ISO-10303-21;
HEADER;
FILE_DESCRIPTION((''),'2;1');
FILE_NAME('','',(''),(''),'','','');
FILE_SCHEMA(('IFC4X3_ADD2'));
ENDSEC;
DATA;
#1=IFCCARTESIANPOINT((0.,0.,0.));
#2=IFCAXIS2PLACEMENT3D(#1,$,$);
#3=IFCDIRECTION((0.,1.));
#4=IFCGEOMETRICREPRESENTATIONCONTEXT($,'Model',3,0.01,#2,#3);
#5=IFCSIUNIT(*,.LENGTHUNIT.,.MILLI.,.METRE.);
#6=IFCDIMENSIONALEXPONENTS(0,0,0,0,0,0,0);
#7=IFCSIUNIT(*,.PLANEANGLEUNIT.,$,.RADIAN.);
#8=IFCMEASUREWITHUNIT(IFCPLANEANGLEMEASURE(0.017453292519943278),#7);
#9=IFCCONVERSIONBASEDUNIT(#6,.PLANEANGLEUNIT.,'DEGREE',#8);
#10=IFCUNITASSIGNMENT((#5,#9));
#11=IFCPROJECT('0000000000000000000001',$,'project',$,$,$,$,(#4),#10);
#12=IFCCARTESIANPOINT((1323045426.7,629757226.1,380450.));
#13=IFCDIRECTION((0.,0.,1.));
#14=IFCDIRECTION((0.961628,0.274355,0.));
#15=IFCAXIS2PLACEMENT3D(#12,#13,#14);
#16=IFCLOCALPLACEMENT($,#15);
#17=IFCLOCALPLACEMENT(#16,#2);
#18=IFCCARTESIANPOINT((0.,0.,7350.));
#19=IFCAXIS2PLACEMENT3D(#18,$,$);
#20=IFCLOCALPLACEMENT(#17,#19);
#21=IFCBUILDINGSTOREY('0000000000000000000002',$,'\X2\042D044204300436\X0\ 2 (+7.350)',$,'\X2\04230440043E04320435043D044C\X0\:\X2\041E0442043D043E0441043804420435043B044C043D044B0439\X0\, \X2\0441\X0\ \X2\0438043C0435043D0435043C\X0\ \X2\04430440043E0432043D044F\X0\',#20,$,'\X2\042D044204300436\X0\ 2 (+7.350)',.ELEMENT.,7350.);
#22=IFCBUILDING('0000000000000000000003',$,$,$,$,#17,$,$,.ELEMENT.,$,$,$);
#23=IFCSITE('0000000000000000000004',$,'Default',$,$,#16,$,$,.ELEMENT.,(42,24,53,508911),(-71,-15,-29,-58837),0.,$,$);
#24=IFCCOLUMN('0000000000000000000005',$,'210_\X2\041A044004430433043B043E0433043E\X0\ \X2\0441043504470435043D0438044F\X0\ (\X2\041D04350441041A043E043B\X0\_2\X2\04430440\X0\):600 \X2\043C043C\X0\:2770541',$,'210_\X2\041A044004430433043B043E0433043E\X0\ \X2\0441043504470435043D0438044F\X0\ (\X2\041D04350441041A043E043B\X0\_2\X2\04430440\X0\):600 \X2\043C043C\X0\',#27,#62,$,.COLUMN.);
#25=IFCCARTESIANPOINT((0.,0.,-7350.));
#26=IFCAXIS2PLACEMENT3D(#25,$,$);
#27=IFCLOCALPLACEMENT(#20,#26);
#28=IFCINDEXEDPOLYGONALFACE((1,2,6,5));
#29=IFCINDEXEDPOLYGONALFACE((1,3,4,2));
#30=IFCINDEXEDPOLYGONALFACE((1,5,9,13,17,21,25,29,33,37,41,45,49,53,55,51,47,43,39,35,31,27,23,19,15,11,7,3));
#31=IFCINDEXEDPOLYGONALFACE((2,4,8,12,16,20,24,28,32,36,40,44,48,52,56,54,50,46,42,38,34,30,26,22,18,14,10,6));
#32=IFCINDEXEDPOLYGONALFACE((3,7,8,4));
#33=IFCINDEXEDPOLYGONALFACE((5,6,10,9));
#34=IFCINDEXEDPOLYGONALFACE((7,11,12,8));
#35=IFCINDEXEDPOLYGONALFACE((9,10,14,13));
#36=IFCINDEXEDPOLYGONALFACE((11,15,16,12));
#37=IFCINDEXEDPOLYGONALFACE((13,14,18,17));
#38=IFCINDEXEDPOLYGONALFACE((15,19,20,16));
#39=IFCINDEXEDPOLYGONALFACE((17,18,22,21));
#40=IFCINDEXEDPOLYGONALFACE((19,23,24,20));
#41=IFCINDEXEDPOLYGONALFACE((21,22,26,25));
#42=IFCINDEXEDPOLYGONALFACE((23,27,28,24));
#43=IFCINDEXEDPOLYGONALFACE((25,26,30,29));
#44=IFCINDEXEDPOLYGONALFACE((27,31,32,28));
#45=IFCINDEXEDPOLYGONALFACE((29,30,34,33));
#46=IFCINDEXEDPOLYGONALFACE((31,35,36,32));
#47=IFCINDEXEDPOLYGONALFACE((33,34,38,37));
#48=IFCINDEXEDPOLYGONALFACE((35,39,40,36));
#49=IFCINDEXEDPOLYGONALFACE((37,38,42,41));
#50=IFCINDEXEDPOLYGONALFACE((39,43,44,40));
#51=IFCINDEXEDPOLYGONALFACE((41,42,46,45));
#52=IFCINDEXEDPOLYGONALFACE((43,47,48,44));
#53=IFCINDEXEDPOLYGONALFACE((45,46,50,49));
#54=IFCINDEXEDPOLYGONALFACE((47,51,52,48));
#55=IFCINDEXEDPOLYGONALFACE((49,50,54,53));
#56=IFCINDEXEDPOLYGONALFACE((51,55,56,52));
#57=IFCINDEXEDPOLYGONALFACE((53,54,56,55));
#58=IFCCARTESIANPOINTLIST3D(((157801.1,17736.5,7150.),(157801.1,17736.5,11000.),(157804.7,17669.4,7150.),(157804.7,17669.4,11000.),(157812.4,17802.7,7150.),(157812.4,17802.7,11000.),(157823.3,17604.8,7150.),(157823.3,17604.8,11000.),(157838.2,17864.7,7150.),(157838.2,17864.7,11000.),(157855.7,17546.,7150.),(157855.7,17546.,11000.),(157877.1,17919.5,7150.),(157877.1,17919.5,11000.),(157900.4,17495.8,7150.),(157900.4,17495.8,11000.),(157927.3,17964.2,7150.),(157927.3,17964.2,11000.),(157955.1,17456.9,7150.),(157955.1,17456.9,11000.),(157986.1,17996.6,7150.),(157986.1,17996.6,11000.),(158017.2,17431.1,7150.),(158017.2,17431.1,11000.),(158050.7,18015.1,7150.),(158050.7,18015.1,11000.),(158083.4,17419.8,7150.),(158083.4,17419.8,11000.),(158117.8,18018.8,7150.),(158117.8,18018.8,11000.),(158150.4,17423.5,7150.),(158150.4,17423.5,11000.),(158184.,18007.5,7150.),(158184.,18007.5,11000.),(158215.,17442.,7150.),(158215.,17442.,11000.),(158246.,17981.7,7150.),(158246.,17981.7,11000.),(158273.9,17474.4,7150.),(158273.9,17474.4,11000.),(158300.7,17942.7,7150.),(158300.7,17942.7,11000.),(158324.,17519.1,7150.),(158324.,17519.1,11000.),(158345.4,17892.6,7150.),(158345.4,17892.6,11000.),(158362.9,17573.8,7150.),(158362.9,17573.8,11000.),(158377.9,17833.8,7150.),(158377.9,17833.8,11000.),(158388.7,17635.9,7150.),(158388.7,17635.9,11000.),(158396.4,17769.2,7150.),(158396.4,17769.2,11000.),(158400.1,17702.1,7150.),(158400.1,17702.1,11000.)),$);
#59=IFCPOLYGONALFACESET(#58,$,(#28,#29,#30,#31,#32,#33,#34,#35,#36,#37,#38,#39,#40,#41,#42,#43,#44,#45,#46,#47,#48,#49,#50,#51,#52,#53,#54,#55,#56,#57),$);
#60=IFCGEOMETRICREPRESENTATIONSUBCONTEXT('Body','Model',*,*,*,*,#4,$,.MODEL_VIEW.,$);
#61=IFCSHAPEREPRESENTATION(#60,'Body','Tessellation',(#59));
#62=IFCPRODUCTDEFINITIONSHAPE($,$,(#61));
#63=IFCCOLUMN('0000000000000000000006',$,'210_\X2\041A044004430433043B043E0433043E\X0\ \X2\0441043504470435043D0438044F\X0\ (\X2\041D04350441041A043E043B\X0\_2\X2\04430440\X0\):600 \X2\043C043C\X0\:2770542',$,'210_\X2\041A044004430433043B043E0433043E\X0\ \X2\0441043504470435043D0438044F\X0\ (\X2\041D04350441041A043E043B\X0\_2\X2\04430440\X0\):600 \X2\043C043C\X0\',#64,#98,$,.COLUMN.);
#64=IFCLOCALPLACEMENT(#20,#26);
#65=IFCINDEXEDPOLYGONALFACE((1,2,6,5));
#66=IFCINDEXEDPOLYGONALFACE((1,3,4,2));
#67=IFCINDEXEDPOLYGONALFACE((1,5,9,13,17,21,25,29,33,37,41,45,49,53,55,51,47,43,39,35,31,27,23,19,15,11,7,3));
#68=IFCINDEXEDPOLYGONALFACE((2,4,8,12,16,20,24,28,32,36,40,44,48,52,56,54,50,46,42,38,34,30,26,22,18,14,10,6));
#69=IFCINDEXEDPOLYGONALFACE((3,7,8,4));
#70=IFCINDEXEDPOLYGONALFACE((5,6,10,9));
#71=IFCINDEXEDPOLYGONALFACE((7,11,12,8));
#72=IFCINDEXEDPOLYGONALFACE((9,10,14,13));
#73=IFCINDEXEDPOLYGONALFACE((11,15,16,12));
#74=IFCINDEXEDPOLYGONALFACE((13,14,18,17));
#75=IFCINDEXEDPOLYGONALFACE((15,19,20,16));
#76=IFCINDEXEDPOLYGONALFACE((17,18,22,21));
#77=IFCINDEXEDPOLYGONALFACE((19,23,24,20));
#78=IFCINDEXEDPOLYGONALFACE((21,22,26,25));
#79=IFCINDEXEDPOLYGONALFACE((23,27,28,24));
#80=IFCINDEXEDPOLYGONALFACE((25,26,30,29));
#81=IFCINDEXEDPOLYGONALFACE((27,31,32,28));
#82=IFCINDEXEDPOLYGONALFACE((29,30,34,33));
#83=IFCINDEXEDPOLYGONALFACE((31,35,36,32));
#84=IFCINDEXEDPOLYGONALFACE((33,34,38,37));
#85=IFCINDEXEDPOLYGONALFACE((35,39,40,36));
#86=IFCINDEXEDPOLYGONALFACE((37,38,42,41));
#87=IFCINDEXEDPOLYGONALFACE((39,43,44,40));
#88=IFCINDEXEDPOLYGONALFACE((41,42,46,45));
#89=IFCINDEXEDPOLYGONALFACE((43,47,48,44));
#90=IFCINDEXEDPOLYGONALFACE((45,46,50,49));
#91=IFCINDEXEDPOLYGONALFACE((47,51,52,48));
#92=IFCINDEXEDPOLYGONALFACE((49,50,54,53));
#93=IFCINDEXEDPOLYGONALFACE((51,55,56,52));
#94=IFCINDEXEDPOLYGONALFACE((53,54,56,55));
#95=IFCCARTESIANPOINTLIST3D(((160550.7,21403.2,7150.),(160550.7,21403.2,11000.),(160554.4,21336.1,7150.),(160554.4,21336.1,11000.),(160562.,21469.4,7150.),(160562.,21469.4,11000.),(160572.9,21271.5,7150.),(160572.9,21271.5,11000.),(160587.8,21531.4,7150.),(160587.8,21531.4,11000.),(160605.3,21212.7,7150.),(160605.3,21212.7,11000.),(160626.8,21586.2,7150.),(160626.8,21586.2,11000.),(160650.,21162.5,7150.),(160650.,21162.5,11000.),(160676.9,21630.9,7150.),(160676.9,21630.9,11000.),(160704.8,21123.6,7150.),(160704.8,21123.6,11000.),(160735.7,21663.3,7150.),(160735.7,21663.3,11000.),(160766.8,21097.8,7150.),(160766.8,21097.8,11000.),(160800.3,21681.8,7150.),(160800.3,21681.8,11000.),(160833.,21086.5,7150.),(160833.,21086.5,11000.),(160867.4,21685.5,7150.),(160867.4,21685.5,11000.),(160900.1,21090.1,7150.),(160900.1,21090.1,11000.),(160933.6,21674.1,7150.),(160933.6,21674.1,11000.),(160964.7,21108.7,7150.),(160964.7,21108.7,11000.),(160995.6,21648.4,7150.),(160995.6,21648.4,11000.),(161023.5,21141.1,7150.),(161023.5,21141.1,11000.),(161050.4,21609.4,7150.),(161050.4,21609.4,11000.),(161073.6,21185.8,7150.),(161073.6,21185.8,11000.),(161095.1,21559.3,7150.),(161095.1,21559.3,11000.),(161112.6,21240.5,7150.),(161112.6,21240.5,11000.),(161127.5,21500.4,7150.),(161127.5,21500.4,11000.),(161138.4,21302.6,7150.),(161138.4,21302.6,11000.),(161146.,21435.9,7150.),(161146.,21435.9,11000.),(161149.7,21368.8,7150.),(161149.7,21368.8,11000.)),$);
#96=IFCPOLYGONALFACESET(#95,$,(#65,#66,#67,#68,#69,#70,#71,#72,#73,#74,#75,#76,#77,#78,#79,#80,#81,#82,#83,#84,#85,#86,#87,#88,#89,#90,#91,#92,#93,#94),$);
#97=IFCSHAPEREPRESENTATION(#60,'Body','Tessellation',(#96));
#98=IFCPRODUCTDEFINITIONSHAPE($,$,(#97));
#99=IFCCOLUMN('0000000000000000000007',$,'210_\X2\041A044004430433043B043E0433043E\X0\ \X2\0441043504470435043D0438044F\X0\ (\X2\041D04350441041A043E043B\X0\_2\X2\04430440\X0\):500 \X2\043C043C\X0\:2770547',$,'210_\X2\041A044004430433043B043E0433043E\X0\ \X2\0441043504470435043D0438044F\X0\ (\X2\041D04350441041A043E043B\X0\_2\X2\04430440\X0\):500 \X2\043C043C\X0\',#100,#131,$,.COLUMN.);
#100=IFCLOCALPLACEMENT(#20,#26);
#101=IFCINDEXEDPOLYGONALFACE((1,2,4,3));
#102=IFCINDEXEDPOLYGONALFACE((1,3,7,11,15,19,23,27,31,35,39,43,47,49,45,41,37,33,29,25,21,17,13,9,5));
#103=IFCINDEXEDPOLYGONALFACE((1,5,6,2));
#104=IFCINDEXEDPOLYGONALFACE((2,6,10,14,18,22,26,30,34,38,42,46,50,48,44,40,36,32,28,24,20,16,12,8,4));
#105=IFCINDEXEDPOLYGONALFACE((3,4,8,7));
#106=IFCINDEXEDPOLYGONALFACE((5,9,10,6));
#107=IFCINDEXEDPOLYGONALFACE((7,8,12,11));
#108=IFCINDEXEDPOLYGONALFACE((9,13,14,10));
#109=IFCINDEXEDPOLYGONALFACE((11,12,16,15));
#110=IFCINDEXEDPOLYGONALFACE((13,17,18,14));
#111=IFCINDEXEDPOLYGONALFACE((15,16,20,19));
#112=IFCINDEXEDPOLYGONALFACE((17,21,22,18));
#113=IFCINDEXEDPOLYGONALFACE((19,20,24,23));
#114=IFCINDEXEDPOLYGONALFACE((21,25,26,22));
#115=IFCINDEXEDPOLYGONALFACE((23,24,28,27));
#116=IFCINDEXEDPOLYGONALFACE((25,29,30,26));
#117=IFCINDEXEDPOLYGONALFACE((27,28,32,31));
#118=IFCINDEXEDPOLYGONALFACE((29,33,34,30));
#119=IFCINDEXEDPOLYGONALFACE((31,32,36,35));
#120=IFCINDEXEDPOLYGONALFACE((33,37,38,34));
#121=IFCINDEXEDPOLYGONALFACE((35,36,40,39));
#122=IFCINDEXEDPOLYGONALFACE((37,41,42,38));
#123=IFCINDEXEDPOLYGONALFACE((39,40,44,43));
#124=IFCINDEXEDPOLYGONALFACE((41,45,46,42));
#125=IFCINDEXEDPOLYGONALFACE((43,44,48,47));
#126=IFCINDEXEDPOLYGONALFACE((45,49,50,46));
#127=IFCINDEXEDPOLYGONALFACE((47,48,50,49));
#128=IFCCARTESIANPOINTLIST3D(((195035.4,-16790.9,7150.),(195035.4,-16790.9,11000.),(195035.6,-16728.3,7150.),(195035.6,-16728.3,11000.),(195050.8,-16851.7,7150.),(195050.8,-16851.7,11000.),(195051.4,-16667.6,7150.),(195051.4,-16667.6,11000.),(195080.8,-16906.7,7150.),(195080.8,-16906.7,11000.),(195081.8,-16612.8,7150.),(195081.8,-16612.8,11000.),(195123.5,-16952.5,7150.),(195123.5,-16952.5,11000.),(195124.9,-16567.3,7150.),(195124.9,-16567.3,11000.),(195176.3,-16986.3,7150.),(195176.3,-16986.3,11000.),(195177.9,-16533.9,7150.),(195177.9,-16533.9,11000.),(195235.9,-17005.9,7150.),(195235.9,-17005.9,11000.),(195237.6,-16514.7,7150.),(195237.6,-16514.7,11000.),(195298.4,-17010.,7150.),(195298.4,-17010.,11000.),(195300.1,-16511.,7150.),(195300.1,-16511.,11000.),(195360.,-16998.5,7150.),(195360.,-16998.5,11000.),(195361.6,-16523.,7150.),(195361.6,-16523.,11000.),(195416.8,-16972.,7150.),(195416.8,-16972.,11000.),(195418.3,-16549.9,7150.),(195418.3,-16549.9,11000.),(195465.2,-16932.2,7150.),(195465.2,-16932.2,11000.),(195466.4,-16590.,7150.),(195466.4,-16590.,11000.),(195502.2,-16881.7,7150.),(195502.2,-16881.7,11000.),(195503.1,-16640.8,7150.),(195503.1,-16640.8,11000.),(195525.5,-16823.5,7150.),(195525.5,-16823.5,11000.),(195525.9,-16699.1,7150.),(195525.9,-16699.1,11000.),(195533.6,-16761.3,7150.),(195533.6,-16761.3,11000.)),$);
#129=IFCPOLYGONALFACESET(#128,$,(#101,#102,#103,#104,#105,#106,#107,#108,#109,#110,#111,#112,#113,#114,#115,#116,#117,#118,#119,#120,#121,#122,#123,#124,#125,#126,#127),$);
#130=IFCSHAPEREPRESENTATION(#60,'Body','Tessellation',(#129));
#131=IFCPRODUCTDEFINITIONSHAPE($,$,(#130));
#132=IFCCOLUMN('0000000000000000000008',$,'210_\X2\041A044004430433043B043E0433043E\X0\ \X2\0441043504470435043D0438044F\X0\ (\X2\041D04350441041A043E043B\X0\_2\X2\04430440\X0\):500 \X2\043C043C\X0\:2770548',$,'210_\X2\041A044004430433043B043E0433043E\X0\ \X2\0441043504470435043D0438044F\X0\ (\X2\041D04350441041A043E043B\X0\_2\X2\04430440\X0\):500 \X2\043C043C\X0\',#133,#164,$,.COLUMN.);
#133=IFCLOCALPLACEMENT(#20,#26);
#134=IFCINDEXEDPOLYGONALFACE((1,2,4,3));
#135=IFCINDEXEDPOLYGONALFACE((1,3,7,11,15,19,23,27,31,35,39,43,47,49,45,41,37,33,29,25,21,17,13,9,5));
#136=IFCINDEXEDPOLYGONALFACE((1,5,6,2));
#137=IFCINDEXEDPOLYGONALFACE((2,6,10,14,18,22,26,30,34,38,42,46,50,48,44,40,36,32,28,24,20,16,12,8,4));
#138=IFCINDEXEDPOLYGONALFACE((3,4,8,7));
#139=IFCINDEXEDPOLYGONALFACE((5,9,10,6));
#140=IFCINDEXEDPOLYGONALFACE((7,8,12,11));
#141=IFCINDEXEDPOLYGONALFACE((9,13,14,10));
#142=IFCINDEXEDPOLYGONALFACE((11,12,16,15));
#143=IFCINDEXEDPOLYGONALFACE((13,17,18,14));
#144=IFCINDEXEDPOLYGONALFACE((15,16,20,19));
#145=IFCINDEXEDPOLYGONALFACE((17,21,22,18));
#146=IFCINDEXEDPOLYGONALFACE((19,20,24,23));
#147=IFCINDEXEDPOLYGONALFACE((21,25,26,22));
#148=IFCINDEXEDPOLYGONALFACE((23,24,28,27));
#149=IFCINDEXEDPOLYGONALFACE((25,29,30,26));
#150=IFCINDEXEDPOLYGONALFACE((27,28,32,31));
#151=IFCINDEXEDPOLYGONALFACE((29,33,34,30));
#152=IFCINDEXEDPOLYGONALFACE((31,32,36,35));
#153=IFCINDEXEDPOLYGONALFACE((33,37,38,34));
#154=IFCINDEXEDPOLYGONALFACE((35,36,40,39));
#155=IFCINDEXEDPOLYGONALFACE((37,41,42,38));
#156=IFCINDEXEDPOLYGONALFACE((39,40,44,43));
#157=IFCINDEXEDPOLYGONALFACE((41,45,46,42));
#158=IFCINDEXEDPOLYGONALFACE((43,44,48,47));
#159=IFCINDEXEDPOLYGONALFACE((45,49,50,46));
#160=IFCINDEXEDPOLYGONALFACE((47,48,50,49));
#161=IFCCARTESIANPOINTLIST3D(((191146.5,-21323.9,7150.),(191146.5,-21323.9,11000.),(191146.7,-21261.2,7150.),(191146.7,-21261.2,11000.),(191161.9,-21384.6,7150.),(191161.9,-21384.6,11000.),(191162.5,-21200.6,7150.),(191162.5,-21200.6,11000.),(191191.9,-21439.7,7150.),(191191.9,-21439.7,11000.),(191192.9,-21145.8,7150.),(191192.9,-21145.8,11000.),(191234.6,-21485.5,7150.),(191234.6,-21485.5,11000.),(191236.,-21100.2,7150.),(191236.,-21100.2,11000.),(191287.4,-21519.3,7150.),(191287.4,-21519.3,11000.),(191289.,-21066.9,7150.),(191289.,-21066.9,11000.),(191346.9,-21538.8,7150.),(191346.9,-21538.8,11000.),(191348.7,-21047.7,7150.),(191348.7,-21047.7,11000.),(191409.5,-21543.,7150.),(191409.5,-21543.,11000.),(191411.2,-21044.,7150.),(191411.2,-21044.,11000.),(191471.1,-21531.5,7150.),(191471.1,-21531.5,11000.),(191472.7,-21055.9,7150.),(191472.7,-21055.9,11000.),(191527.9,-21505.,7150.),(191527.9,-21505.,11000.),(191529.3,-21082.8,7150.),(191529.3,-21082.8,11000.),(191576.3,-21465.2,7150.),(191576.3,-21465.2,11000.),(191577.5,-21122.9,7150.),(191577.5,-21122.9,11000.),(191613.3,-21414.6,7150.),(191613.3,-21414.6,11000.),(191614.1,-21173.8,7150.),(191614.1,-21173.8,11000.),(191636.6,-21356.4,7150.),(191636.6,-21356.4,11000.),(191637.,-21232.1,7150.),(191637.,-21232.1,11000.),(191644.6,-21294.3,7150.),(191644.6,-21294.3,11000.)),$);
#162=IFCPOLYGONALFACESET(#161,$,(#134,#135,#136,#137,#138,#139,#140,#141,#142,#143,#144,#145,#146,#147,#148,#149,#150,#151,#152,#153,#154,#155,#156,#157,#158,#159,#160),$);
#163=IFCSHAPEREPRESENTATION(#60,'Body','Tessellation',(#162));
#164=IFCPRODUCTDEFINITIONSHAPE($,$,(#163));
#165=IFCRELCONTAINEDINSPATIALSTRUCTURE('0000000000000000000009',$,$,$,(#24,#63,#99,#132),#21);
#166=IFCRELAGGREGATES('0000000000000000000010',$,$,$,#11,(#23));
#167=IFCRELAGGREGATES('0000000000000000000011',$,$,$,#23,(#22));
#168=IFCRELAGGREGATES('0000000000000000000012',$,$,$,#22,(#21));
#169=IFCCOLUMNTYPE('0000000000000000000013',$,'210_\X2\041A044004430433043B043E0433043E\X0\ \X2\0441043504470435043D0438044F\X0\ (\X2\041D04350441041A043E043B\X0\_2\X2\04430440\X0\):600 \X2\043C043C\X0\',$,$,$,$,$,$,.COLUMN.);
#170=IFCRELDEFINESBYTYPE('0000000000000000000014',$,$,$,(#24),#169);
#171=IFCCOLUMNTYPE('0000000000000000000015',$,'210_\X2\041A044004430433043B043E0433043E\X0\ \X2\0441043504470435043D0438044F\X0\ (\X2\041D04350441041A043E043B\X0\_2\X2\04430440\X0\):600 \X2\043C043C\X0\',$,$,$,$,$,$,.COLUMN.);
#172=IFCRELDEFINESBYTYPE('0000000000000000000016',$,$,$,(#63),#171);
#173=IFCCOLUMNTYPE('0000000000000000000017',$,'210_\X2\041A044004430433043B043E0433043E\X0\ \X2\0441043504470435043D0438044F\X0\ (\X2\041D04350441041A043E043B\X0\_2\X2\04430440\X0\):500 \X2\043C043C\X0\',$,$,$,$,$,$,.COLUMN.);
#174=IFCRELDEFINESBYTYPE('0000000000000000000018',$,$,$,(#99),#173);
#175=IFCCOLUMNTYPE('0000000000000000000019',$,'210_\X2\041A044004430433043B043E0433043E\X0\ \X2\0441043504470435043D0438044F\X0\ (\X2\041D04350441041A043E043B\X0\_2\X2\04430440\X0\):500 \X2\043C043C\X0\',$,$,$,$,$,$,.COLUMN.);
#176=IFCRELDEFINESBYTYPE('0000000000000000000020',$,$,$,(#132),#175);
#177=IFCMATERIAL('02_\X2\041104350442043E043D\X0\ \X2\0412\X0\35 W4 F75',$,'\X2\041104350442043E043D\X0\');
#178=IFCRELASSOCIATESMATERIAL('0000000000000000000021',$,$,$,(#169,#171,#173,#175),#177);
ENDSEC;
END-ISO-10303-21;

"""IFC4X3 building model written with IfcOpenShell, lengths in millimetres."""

from ifc_helpers import new_model, entity, si_unit, converted_unit, direction, frame, frame_2d, origin, origin_2d_with_axis, place, context, subcontext, project, spatial, circle, extrude, source, transform, mapped, material, material_profile, profile_set, type_object, type_shapes, element, save


model = new_model("IFC4X3")

# Units and contexts
model_context = context("Model", 3, precision=0.01, world=origin(), true_north=direction((0.0, 1.0)))
body_context = subcontext(model_context, "Body", "Model", "MODEL_VIEW")
ifc_project = project(units=[si_unit("LENGTHUNIT", "METRE", prefix="MILLI"), converted_unit("PLANEANGLEUNIT", "DEGREE", entity("IfcPlaneAngleMeasure", 0.017453292519943278), si_unit("PLANEANGLEUNIT", "RADIAN"), dimensions=[0, 0, 0, 0, 0, 0, 0])], contexts=[model_context])

# Site, building, storey
site_placement = place(None, frame((1323045426.7, 629757226.1, 380450.0), z_axis=(0.0, 0.0, 1.0), x_axis=(0.961628, 0.274355, 0.0)))
site = spatial("IfcSite", under=ifc_project, at=site_placement, Name="Default", CompositionType="ELEMENT", RefLatitude=(42, 24, 53, 508911), RefLongitude=(-71, -15, -29, -58837), RefElevation=0.0)
building_placement = place(site_placement, origin())
building = spatial("IfcBuilding", under=site, at=building_placement, CompositionType="ELEMENT")
storey_placement = place(building_placement, frame((0.0, 0.0, 7350.0)))
storey = spatial("IfcBuildingStorey", under=building, at=storey_placement, Name="Этаж 2 (+7.350)", ObjectType="Уровень:Относительный, с именем уровня", LongName="Этаж 2 (+7.350)", CompositionType="ELEMENT", Elevation=7350.0)

# Columns
ifc_material = material(Name="02_Бетон В35 W4 F75", Category="Бетон")
ifc_material_profile_1 = material_profile(ifc_material, circle(Radius=250.0, at=frame_2d((0.0, 0.0), x_axis=(1.0, 0.0))), Name="500 мм")
ifc_profile_set_1 = profile_set([ifc_material_profile_1], Name="500 мм")
ifc_material_profile_2 = material_profile(ifc_material, circle(Radius=300.0, at=origin_2d_with_axis()), Name="600 мм")
ifc_profile_set_2 = profile_set([ifc_material_profile_2], Name="600 мм")
column_type_1 = type_object("IfcColumnType", Name="210_Круглого сечения (НесКол_2ур):600 мм", PredefinedType="COLUMN", material=ifc_profile_set_2)
shared_shape_1 = source(origin(), body_context, "Body", "SweptSolid", [
    extrude(circle(Radius=300.0, at=origin_2d_with_axis()), frame((158100.6, 17719.3, 7150.0), z_axis=(0.0, 0.0, 1.0), x_axis=(0.87462, -0.48481, 0.0)), (0.0, 0.0, 1.0), 3850.0),
])
type_shapes(column_type_1, [shared_shape_1])
column_1_placement = place(storey_placement, frame((0.0, 0.0, -7350.0)))
element("IfcColumn", 1, at=column_1_placement, inside=storey, type_object=column_type_1, Name="210_Круглого сечения (НесКол_2ур):600 мм:2770541", ObjectType="210_Круглого сечения (НесКол_2ур):600 мм", PredefinedType="COLUMN", context=body_context, shape_type="MappedRepresentation", body=[
    mapped(shared_shape_1, transform((0.0, 0.0, 0.0), scale=1.0)),
])
column_type_2 = type_object("IfcColumnType", Name="210_Круглого сечения (НесКол_2ур):600 мм", PredefinedType="COLUMN", material=ifc_profile_set_2)
shared_shape_2 = source(origin(), body_context, "Body", "SweptSolid", [
    extrude(circle(Radius=300.0, at=origin_2d_with_axis()), frame((160850.2, 21386.0, 7150.0), z_axis=(0.0, 0.0, 1.0), x_axis=(0.87462, -0.48481, 0.0)), (0.0, 0.0, 1.0), 3850.0),
])
type_shapes(column_type_2, [shared_shape_2])
column_2_placement = place(storey_placement, frame((0.0, 0.0, -7350.0)))
element("IfcColumn", 2, at=column_2_placement, inside=storey, type_object=column_type_2, Name="210_Круглого сечения (НесКол_2ур):600 мм:2770542", ObjectType="210_Круглого сечения (НесКол_2ур):600 мм", PredefinedType="COLUMN", context=body_context, shape_type="MappedRepresentation", body=[
    mapped(shared_shape_2, transform((0.0, 0.0, 0.0), scale=1.0)),
])
column_type_3 = type_object("IfcColumnType", Name="210_Круглого сечения (НесКол_2ур):500 мм", PredefinedType="COLUMN", material=ifc_profile_set_1)
shared_shape_3 = source(origin(), body_context, "Body", "SweptSolid", [
    extrude(circle(Radius=250.0, at=origin_2d_with_axis()), frame((195283.6, -16760.5, 7150.0), z_axis=(0.0, 0.0, 1.0), x_axis=(0.87462, -0.48481, 0.0)), (0.0, 0.0, 1.0), 3850.0),
])
type_shapes(column_type_3, [shared_shape_3])
column_3_placement = place(storey_placement, frame((0.0, 0.0, -7350.0)))
element("IfcColumn", 3, at=column_3_placement, inside=storey, type_object=column_type_3, Name="210_Круглого сечения (НесКол_2ур):500 мм:2770547", ObjectType="210_Круглого сечения (НесКол_2ур):500 мм", PredefinedType="COLUMN", context=body_context, shape_type="MappedRepresentation", body=[
    mapped(shared_shape_3, transform((0.0, 0.0, 0.0), scale=1.0)),
])
column_type_4 = type_object("IfcColumnType", Name="210_Круглого сечения (НесКол_2ур):500 мм", PredefinedType="COLUMN", material=ifc_profile_set_1)
shared_shape_4 = source(origin(), body_context, "Body", "SweptSolid", [
    extrude(circle(Radius=250.0, at=origin_2d_with_axis()), frame((191394.6, -21293.4, 7150.0), z_axis=(0.0, 0.0, 1.0), x_axis=(0.87462, -0.48481, 0.0)), (0.0, 0.0, 1.0), 3850.0),
])
type_shapes(column_type_4, [shared_shape_4])
column_4_placement = place(storey_placement, frame((0.0, 0.0, -7350.0)))
element("IfcColumn", 4, at=column_4_placement, inside=storey, type_object=column_type_4, Name="210_Круглого сечения (НесКол_2ур):500 мм:2770548", ObjectType="210_Круглого сечения (НесКол_2ур):500 мм", PredefinedType="COLUMN", context=body_context, shape_type="MappedRepresentation", body=[
    mapped(shared_shape_4, transform((0.0, 0.0, 0.0), scale=1.0)),
])

save(model, "model.ifc")
